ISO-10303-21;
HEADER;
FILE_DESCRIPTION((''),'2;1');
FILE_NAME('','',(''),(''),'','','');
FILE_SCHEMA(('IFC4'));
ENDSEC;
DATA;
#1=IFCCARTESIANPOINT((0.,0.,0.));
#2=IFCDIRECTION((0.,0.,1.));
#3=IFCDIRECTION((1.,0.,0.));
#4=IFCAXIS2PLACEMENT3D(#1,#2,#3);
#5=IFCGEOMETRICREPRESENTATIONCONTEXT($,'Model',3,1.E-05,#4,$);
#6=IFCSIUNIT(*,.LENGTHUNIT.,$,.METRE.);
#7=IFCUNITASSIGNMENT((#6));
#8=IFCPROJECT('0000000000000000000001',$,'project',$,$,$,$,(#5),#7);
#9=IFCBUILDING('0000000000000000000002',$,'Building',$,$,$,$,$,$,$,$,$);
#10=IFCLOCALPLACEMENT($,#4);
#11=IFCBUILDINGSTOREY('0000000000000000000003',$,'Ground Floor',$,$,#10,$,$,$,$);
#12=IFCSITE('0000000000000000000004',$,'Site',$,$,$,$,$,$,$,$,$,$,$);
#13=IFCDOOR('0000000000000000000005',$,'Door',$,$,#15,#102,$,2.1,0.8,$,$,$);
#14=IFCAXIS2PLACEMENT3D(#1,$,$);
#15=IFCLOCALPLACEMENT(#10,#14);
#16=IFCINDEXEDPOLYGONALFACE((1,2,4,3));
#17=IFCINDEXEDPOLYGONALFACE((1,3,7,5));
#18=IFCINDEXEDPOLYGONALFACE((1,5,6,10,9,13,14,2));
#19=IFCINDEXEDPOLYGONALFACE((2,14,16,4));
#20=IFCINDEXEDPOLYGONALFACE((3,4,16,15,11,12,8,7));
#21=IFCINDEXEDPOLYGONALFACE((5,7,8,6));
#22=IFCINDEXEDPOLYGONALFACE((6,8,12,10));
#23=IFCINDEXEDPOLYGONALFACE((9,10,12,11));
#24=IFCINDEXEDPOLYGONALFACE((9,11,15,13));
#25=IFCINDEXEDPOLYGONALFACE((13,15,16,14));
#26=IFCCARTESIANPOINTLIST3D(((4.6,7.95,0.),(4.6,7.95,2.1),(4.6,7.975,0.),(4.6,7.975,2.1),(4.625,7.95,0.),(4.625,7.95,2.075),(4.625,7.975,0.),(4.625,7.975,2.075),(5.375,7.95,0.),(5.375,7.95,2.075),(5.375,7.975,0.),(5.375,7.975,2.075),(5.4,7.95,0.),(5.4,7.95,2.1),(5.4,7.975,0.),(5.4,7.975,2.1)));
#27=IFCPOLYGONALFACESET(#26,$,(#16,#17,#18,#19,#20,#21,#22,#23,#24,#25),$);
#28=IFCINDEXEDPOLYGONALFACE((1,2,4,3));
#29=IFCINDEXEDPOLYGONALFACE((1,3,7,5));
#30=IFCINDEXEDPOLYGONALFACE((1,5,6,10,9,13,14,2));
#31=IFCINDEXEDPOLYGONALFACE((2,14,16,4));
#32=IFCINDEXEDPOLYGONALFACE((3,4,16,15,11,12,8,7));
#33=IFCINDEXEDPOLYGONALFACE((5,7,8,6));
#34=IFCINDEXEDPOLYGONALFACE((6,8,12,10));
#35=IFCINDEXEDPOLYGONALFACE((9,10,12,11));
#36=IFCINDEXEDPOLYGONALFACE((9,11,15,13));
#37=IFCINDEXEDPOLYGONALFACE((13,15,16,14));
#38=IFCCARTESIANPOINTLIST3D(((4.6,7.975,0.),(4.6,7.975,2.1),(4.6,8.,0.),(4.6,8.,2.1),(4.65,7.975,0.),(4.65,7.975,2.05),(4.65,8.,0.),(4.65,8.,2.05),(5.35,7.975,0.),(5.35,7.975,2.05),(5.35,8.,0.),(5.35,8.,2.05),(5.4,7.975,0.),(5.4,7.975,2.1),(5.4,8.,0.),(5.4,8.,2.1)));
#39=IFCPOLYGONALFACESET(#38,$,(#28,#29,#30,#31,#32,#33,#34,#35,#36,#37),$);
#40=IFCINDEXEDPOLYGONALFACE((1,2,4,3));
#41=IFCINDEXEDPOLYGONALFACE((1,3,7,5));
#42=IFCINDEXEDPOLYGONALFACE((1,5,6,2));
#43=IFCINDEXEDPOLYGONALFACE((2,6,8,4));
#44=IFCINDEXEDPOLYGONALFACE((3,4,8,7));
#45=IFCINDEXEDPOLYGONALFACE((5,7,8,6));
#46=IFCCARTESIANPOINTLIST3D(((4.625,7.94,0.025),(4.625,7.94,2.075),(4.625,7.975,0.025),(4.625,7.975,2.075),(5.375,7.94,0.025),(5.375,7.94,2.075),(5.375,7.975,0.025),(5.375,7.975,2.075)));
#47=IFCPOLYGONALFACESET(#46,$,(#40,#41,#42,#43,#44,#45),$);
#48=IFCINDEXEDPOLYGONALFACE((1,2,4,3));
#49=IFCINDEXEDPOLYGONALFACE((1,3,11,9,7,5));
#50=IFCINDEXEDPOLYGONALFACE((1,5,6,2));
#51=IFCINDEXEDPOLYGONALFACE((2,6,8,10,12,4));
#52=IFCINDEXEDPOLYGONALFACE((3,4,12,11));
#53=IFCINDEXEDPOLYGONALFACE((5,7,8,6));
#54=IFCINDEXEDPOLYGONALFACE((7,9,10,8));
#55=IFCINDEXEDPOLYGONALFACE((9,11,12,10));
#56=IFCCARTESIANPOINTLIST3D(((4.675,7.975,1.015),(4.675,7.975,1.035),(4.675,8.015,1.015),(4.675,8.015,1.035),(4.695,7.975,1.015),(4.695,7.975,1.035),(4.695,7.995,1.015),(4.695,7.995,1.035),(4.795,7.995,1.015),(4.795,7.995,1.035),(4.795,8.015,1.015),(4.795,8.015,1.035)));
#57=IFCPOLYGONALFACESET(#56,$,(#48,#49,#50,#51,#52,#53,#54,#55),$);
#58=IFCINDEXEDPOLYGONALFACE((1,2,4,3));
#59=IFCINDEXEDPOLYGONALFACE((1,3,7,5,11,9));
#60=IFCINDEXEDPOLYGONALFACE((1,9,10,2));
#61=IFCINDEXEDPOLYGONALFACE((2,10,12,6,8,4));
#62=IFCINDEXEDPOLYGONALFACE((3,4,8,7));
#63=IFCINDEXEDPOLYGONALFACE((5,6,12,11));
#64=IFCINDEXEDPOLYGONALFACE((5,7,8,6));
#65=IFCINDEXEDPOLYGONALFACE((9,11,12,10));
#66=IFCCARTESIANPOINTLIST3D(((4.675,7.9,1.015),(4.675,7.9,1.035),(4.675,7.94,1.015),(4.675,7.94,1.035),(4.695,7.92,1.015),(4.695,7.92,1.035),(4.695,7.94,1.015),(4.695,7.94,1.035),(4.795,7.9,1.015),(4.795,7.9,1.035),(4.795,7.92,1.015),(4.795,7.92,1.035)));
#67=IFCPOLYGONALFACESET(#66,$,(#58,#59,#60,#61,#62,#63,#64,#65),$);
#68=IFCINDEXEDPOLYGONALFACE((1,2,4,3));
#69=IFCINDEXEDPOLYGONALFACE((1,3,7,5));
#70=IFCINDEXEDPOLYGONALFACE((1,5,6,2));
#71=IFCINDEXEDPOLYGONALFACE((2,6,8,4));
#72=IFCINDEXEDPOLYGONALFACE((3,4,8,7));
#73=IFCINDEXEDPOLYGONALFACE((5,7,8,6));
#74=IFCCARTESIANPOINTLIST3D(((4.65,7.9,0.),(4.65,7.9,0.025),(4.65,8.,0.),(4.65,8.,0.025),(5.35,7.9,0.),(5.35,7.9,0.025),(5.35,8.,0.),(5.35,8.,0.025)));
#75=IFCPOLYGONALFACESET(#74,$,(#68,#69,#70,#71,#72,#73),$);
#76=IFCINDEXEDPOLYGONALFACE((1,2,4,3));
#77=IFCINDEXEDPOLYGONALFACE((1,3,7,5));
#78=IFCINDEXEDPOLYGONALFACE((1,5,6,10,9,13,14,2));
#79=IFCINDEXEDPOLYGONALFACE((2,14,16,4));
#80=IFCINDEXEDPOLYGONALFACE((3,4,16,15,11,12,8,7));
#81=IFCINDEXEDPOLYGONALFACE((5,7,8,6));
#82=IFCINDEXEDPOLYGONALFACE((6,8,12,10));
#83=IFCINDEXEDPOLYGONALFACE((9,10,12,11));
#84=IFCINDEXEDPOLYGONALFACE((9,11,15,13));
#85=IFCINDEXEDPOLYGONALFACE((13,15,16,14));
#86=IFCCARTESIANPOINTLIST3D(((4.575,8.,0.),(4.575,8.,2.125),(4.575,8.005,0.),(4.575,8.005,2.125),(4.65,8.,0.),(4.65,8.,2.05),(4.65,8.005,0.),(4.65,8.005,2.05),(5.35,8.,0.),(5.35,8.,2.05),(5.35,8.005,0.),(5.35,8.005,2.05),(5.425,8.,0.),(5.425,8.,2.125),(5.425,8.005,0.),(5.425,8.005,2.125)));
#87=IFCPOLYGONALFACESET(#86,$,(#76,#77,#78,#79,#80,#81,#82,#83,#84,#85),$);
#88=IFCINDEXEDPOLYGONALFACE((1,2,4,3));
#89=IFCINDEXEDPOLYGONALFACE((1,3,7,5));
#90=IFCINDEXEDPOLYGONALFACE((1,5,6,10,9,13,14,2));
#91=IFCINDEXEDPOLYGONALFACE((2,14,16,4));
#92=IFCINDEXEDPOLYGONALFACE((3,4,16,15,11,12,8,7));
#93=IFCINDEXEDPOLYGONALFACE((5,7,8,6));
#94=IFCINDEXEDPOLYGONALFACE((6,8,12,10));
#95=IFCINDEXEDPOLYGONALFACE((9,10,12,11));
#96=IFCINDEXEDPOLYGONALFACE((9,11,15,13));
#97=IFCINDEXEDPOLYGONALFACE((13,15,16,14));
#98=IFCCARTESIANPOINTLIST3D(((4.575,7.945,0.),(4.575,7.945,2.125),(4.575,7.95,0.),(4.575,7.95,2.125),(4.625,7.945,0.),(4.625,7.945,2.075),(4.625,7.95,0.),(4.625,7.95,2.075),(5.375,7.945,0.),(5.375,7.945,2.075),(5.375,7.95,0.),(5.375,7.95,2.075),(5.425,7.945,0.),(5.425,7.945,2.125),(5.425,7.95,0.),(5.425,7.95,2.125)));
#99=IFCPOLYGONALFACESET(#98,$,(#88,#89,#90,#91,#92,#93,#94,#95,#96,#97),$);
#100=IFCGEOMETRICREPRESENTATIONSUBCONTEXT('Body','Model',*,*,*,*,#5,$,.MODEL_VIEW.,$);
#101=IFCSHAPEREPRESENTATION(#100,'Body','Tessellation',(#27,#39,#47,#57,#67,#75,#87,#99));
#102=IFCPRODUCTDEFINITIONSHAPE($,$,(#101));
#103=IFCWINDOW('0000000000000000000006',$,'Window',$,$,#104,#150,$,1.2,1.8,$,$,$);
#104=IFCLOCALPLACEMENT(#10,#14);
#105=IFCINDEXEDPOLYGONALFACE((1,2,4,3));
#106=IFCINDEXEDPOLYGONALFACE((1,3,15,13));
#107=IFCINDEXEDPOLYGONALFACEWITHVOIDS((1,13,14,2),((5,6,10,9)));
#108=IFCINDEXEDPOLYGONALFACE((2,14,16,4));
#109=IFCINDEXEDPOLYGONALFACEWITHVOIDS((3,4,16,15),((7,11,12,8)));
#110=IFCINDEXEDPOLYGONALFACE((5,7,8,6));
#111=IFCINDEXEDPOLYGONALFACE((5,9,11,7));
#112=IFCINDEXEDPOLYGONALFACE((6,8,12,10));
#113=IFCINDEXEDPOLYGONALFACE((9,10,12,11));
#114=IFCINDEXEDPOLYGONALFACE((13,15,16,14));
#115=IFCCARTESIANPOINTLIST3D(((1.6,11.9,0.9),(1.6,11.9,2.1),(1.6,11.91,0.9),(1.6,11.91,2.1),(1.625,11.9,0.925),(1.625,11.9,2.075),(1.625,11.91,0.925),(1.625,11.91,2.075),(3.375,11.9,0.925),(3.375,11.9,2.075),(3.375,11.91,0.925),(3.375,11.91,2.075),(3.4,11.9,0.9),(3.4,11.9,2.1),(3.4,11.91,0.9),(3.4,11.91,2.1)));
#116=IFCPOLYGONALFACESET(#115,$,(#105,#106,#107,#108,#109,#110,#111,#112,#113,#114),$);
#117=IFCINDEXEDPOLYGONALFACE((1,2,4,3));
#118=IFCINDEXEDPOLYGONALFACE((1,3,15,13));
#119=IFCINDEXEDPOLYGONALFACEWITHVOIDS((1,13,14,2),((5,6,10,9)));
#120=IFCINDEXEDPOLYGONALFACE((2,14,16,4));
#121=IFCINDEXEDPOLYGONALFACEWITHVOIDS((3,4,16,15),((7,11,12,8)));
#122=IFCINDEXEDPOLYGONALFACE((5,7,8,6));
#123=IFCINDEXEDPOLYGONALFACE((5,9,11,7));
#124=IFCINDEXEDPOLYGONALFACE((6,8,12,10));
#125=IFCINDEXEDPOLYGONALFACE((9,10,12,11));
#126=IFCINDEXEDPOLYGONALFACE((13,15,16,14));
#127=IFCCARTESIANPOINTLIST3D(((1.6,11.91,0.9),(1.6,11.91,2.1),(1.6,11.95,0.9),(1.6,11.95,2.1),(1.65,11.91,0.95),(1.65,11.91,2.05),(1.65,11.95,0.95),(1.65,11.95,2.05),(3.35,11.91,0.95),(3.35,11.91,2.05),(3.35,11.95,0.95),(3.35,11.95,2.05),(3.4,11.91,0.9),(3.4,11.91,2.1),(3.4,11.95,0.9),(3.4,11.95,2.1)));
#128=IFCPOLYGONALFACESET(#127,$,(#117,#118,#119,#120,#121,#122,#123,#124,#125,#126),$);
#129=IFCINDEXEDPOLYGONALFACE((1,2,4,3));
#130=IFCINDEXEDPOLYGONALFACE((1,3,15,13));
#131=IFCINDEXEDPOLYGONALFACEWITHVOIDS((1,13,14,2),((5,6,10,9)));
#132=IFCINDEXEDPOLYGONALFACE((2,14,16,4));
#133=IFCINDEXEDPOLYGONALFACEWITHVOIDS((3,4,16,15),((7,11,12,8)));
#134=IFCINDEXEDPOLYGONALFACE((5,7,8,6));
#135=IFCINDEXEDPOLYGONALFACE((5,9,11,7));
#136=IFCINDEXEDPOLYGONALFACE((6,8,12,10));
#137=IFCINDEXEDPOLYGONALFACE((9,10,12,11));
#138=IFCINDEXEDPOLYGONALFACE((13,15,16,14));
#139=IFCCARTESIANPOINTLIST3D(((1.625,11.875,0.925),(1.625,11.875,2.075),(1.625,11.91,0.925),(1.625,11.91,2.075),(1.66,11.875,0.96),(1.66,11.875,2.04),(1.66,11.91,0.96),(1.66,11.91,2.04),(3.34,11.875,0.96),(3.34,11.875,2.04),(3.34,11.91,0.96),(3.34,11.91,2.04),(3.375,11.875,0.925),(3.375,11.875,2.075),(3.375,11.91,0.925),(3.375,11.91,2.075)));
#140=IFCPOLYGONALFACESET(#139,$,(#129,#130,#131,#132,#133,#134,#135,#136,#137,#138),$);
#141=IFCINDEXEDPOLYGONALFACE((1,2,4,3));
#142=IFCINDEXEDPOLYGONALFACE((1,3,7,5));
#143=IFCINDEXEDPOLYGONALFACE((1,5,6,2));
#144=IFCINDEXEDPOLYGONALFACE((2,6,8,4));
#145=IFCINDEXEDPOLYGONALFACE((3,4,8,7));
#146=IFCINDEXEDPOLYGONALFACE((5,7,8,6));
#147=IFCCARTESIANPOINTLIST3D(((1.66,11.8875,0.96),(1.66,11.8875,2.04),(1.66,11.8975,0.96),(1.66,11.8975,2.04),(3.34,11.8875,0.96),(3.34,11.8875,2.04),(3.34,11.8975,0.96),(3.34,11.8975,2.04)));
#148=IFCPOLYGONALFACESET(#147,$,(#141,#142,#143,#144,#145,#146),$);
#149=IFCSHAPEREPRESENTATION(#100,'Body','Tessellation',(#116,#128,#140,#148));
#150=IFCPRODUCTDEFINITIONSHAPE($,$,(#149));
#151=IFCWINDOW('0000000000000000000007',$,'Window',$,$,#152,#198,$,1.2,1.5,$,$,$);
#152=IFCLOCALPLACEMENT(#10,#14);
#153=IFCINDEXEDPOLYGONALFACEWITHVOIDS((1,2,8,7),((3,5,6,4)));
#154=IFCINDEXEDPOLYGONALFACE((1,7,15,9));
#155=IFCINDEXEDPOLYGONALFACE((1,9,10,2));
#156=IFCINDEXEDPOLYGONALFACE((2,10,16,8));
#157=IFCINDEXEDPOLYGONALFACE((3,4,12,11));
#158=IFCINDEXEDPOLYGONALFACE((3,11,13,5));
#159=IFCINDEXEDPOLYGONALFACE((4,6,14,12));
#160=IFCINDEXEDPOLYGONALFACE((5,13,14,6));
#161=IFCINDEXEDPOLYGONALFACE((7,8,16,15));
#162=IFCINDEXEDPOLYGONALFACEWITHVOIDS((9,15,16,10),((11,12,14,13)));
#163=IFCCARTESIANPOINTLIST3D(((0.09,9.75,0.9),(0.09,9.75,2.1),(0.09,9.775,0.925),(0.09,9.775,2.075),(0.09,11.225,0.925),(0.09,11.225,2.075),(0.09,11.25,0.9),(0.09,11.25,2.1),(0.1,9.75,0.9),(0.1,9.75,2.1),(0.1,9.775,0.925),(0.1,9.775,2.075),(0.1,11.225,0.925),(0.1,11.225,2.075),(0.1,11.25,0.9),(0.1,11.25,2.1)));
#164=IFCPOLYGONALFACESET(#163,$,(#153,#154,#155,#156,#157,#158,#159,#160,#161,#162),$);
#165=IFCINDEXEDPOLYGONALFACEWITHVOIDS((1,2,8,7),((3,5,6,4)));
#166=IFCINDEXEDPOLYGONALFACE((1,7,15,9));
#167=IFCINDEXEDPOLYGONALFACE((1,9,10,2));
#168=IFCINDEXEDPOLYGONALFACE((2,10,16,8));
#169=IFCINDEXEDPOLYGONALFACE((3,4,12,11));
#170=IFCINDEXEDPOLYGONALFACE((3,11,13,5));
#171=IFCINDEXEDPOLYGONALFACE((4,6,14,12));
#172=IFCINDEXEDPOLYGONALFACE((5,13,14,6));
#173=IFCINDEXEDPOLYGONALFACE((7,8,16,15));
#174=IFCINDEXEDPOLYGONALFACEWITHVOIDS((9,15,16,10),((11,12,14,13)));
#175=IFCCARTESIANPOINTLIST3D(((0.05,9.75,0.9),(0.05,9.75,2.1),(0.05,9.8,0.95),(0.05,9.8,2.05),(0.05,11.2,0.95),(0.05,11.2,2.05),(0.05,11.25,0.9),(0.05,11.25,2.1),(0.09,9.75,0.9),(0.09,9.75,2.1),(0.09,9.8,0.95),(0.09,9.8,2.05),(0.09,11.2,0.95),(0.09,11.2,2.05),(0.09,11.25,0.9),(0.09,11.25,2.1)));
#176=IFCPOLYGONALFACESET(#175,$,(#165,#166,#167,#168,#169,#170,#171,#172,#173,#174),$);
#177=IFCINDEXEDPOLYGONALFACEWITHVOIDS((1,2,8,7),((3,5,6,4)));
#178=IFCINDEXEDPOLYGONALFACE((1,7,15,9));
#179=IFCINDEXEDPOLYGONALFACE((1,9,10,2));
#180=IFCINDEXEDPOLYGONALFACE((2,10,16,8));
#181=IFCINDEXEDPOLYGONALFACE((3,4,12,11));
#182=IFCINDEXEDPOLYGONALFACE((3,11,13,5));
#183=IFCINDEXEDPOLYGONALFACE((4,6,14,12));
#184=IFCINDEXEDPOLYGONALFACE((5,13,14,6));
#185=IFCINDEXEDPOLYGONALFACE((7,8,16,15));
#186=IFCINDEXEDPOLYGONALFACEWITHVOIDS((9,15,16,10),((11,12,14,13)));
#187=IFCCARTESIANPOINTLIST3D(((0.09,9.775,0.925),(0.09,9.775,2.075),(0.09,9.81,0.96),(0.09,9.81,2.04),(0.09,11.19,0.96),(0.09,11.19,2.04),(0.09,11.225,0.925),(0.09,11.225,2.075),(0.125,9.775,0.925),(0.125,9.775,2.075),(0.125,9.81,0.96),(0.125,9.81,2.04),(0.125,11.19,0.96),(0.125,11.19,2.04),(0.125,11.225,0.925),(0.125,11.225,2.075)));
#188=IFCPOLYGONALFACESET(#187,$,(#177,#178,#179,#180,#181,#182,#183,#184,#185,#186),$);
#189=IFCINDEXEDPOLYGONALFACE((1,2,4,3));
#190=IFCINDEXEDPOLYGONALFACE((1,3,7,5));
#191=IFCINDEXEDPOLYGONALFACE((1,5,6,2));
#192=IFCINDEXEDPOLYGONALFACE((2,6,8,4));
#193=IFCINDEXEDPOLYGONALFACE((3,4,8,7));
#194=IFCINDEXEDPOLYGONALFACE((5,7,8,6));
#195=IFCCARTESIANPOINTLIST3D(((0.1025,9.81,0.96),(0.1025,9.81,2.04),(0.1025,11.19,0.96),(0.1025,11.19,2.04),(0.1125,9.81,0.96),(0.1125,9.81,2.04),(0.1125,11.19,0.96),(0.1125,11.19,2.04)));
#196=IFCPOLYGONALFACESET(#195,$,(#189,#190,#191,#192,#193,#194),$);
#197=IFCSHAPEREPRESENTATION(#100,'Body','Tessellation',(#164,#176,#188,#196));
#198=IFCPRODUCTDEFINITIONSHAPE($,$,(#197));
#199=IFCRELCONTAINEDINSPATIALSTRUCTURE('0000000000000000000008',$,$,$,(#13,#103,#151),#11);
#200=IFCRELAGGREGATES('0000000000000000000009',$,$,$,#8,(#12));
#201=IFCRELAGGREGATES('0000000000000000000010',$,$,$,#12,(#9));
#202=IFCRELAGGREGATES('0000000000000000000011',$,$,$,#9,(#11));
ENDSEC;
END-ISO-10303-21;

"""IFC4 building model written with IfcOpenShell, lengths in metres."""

from ifc_helpers import new_model, si_unit, frame, origin_with_axes, place, context, subcontext, project, spatial, line, indexed_curve, outline, extrude, element, save


model = new_model("IFC4")

# Units and contexts
model_context = context("Model", 3, precision=1e-05, world=origin_with_axes())
body_context = subcontext(model_context, "Body", "Model", "MODEL_VIEW")
ifc_project = project(units=[si_unit("LENGTHUNIT", "METRE")], contexts=[model_context])

# Site, building, storey
site = spatial("IfcSite", under=ifc_project, Name="Site")
building = spatial("IfcBuilding", under=site, Name="Building")
storey_placement = place(None, origin_with_axes())
storey = spatial("IfcBuildingStorey", under=building, at=storey_placement, Name="Ground Floor")

# Door
door_1_placement = place(storey_placement, frame((5.4, 8.0, 0.0), z_axis=(0.0, 0.0, 1.0), x_axis=(-1.0, 0.0, 0.0)))
element("IfcDoor", 1, at=door_1_placement, inside=storey, Name="Door", OverallHeight=2.1, OverallWidth=0.8, context=body_context, shape_type="SweptSolid", body=[
    extrude(outline(indexed_curve([(0.0, 0.0), (0.0, 2.1), (0.8, 2.1), (0.8, 0.0), (0.775, 0.0), (0.775, 2.075), (0.025, 2.075), (0.025, 0.0)], segments=[line(1, 2, 3, 4, 5, 6, 7, 8, 1)])), frame((0.0, 0.025, 0.0), z_axis=(0.0, -1.0, 0.0), x_axis=(1.0, 0.0, 0.0)), (0.0, 0.0, -1.0), 0.025),
    extrude(outline(indexed_curve([(0.0, 0.0), (0.0, 2.1), (0.8, 2.1), (0.8, 0.0), (0.75, 0.0), (0.75, 2.05), (0.05, 2.05), (0.05, 0.0)], segments=[line(1, 2, 3, 4, 5, 6, 7, 8, 1)])), frame((0.0, 0.0, 0.0), z_axis=(0.0, -1.0, 0.0), x_axis=(1.0, 0.0, 0.0)), (0.0, 0.0, -1.0), 0.025),
    extrude(outline(indexed_curve([(0.0, 0.0), (0.75, 0.0), (0.75, 0.035), (0.0, 0.035)], segments=[line(1, 2, 3, 4, 1)])), frame((0.025, 0.025, 0.025), z_axis=(0.0, 0.0, 1.0), x_axis=(1.0, 0.0, 0.0)), (0.0, 0.0, 1.0), 2.05),
    extrude(outline(indexed_curve([(0.0, 0.0), (0.0, -0.04), (-0.12, -0.04), (-0.12, -0.02), (-0.02, -0.02), (-0.02, 0.0)], segments=[line(1, 2, 3, 4, 5, 6, 1)])), frame((0.725, 0.025, 1.015), z_axis=(0.0, 0.0, 1.0), x_axis=(1.0, 0.0, 0.0)), (0.0, 0.0, 1.0), 0.02),
    extrude(outline(indexed_curve([(0.0, 0.0), (0.0, 0.04), (-0.12, 0.04), (-0.12, 0.02), (-0.02, 0.02), (-0.02, 0.0)], segments=[line(1, 2, 3, 4, 5, 6, 1)])), frame((0.725, 0.06, 1.015), z_axis=(0.0, 0.0, 1.0), x_axis=(1.0, 0.0, 0.0)), (0.0, 0.0, 1.0), 0.02),
    extrude(outline(indexed_curve([(0.0, 0.0), (0.7, 0.0), (0.7, 0.1), (0.0, 0.1)], segments=[line(1, 2, 3, 4, 1)])), frame((0.05, 0.0, 0.0), z_axis=(0.0, 0.0, 1.0), x_axis=(1.0, 0.0, 0.0)), (0.0, 0.0, 1.0), 0.025),
    extrude(outline(indexed_curve([(0.0, 0.0), (0.0, 2.125), (0.85, 2.125), (0.85, 0.0), (0.775, 0.0), (0.775, 2.05), (0.075, 2.05), (0.075, 0.0)], segments=[line(1, 2, 3, 4, 5, 6, 7, 8, 1)])), frame((-0.025, -0.005, 0.0), z_axis=(0.0, -1.0, 0.0), x_axis=(1.0, 0.0, 0.0)), (0.0, 0.0, -1.0), 0.005),
    extrude(outline(indexed_curve([(0.0, 0.0), (0.0, 2.125), (0.85, 2.125), (0.85, 0.0), (0.8, 0.0), (0.8, 2.075), (0.05, 2.075), (0.05, 0.0)], segments=[line(1, 2, 3, 4, 5, 6, 7, 8, 1)])), frame((-0.025, 0.05, 0.0), z_axis=(0.0, -1.0, 0.0), x_axis=(1.0, 0.0, 0.0)), (0.0, 0.0, -1.0), 0.005),
])

# Windows
window_1_placement = place(storey_placement, frame((3.4, 12.0, 0.9), z_axis=(0.0, 0.0, 1.0), x_axis=(-1.0, 0.0, 0.0)))
element("IfcWindow", 2, at=window_1_placement, inside=storey, Name="Window", OverallHeight=1.2, OverallWidth=1.8, context=body_context, shape_type="SweptSolid", body=[
    extrude(outline(indexed_curve([(0.0, 0.0), (1.8, 0.0), (1.8, 1.2), (0.0, 1.2)], segments=[line(1, 2, 3, 4, 1)]), holes=[indexed_curve([(0.025, 0.025), (1.775, 0.025), (1.775, 1.175), (0.025, 1.175)], segments=[line(1, 2, 3, 4, 1)])]), frame((0.0, 0.09, 0.0), z_axis=(0.0, -1.0, 0.0), x_axis=(1.0, 0.0, 0.0)), (0.0, 0.0, -1.0), 0.01),
    extrude(outline(indexed_curve([(0.0, 0.0), (1.8, 0.0), (1.8, 1.2), (0.0, 1.2)], segments=[line(1, 2, 3, 4, 1)]), holes=[indexed_curve([(0.05, 0.05), (1.75, 0.05), (1.75, 1.15), (0.05, 1.15)], segments=[line(1, 2, 3, 4, 1)])]), frame((0.0, 0.05, 0.0), z_axis=(0.0, -1.0, 0.0), x_axis=(1.0, 0.0, 0.0)), (0.0, 0.0, -1.0), 0.04),
    extrude(outline(indexed_curve([(0.0, 0.0), (1.75, 0.0), (1.75, 1.15), (0.0, 1.15)], segments=[line(1, 2, 3, 4, 1)]), holes=[indexed_curve([(0.035, 0.035), (1.715, 0.035), (1.715, 1.115), (0.035, 1.115)], segments=[line(1, 2, 3, 4, 1)])]), frame((0.025, 0.09, 0.025), z_axis=(0.0, -1.0, 0.0), x_axis=(1.0, 0.0, 0.0)), (0.0, 0.0, -1.0), 0.035),
    extrude(outline(indexed_curve([(0.035, 0.035), (1.715, 0.035), (1.715, 1.115), (0.035, 1.115)], segments=[line(1, 2, 3, 4, 1)])), frame((0.025, 0.1025, 0.025), z_axis=(0.0, -1.0, 0.0), x_axis=(1.0, 0.0, 0.0)), (0.0, 0.0, -1.0), 0.01),
])
window_2_placement = place(storey_placement, frame((0.0, 11.25, 0.9), z_axis=(0.0, 0.0, 1.0), x_axis=(0.0, -1.0, 0.0)))
element("IfcWindow", 3, at=window_2_placement, inside=storey, Name="Window", OverallHeight=1.2, OverallWidth=1.5, context=body_context, shape_type="SweptSolid", body=[
    extrude(outline(indexed_curve([(0.0, 0.0), (1.5, 0.0), (1.5, 1.2), (0.0, 1.2)], segments=[line(1, 2, 3, 4, 1)]), holes=[indexed_curve([(0.025, 0.025), (1.475, 0.025), (1.475, 1.175), (0.025, 1.175)], segments=[line(1, 2, 3, 4, 1)])]), frame((0.0, 0.09, 0.0), z_axis=(0.0, -1.0, 0.0), x_axis=(1.0, 0.0, 0.0)), (0.0, 0.0, -1.0), 0.01),
    extrude(outline(indexed_curve([(0.0, 0.0), (1.5, 0.0), (1.5, 1.2), (0.0, 1.2)], segments=[line(1, 2, 3, 4, 1)]), holes=[indexed_curve([(0.05, 0.05), (1.45, 0.05), (1.45, 1.15), (0.05, 1.15)], segments=[line(1, 2, 3, 4, 1)])]), frame((0.0, 0.05, 0.0), z_axis=(0.0, -1.0, 0.0), x_axis=(1.0, 0.0, 0.0)), (0.0, 0.0, -1.0), 0.04),
    extrude(outline(indexed_curve([(0.0, 0.0), (1.45, 0.0), (1.45, 1.15), (0.0, 1.15)], segments=[line(1, 2, 3, 4, 1)]), holes=[indexed_curve([(0.035, 0.035), (1.415, 0.035), (1.415, 1.115), (0.035, 1.115)], segments=[line(1, 2, 3, 4, 1)])]), frame((0.025, 0.09, 0.025), z_axis=(0.0, -1.0, 0.0), x_axis=(1.0, 0.0, 0.0)), (0.0, 0.0, -1.0), 0.035),
    extrude(outline(indexed_curve([(0.035, 0.035), (1.415, 0.035), (1.415, 1.115), (0.035, 1.115)], segments=[line(1, 2, 3, 4, 1)])), frame((0.025, 0.1025, 0.025), z_axis=(0.0, -1.0, 0.0), x_axis=(1.0, 0.0, 0.0)), (0.0, 0.0, -1.0), 0.01),
])

save(model, "model.ifc")
